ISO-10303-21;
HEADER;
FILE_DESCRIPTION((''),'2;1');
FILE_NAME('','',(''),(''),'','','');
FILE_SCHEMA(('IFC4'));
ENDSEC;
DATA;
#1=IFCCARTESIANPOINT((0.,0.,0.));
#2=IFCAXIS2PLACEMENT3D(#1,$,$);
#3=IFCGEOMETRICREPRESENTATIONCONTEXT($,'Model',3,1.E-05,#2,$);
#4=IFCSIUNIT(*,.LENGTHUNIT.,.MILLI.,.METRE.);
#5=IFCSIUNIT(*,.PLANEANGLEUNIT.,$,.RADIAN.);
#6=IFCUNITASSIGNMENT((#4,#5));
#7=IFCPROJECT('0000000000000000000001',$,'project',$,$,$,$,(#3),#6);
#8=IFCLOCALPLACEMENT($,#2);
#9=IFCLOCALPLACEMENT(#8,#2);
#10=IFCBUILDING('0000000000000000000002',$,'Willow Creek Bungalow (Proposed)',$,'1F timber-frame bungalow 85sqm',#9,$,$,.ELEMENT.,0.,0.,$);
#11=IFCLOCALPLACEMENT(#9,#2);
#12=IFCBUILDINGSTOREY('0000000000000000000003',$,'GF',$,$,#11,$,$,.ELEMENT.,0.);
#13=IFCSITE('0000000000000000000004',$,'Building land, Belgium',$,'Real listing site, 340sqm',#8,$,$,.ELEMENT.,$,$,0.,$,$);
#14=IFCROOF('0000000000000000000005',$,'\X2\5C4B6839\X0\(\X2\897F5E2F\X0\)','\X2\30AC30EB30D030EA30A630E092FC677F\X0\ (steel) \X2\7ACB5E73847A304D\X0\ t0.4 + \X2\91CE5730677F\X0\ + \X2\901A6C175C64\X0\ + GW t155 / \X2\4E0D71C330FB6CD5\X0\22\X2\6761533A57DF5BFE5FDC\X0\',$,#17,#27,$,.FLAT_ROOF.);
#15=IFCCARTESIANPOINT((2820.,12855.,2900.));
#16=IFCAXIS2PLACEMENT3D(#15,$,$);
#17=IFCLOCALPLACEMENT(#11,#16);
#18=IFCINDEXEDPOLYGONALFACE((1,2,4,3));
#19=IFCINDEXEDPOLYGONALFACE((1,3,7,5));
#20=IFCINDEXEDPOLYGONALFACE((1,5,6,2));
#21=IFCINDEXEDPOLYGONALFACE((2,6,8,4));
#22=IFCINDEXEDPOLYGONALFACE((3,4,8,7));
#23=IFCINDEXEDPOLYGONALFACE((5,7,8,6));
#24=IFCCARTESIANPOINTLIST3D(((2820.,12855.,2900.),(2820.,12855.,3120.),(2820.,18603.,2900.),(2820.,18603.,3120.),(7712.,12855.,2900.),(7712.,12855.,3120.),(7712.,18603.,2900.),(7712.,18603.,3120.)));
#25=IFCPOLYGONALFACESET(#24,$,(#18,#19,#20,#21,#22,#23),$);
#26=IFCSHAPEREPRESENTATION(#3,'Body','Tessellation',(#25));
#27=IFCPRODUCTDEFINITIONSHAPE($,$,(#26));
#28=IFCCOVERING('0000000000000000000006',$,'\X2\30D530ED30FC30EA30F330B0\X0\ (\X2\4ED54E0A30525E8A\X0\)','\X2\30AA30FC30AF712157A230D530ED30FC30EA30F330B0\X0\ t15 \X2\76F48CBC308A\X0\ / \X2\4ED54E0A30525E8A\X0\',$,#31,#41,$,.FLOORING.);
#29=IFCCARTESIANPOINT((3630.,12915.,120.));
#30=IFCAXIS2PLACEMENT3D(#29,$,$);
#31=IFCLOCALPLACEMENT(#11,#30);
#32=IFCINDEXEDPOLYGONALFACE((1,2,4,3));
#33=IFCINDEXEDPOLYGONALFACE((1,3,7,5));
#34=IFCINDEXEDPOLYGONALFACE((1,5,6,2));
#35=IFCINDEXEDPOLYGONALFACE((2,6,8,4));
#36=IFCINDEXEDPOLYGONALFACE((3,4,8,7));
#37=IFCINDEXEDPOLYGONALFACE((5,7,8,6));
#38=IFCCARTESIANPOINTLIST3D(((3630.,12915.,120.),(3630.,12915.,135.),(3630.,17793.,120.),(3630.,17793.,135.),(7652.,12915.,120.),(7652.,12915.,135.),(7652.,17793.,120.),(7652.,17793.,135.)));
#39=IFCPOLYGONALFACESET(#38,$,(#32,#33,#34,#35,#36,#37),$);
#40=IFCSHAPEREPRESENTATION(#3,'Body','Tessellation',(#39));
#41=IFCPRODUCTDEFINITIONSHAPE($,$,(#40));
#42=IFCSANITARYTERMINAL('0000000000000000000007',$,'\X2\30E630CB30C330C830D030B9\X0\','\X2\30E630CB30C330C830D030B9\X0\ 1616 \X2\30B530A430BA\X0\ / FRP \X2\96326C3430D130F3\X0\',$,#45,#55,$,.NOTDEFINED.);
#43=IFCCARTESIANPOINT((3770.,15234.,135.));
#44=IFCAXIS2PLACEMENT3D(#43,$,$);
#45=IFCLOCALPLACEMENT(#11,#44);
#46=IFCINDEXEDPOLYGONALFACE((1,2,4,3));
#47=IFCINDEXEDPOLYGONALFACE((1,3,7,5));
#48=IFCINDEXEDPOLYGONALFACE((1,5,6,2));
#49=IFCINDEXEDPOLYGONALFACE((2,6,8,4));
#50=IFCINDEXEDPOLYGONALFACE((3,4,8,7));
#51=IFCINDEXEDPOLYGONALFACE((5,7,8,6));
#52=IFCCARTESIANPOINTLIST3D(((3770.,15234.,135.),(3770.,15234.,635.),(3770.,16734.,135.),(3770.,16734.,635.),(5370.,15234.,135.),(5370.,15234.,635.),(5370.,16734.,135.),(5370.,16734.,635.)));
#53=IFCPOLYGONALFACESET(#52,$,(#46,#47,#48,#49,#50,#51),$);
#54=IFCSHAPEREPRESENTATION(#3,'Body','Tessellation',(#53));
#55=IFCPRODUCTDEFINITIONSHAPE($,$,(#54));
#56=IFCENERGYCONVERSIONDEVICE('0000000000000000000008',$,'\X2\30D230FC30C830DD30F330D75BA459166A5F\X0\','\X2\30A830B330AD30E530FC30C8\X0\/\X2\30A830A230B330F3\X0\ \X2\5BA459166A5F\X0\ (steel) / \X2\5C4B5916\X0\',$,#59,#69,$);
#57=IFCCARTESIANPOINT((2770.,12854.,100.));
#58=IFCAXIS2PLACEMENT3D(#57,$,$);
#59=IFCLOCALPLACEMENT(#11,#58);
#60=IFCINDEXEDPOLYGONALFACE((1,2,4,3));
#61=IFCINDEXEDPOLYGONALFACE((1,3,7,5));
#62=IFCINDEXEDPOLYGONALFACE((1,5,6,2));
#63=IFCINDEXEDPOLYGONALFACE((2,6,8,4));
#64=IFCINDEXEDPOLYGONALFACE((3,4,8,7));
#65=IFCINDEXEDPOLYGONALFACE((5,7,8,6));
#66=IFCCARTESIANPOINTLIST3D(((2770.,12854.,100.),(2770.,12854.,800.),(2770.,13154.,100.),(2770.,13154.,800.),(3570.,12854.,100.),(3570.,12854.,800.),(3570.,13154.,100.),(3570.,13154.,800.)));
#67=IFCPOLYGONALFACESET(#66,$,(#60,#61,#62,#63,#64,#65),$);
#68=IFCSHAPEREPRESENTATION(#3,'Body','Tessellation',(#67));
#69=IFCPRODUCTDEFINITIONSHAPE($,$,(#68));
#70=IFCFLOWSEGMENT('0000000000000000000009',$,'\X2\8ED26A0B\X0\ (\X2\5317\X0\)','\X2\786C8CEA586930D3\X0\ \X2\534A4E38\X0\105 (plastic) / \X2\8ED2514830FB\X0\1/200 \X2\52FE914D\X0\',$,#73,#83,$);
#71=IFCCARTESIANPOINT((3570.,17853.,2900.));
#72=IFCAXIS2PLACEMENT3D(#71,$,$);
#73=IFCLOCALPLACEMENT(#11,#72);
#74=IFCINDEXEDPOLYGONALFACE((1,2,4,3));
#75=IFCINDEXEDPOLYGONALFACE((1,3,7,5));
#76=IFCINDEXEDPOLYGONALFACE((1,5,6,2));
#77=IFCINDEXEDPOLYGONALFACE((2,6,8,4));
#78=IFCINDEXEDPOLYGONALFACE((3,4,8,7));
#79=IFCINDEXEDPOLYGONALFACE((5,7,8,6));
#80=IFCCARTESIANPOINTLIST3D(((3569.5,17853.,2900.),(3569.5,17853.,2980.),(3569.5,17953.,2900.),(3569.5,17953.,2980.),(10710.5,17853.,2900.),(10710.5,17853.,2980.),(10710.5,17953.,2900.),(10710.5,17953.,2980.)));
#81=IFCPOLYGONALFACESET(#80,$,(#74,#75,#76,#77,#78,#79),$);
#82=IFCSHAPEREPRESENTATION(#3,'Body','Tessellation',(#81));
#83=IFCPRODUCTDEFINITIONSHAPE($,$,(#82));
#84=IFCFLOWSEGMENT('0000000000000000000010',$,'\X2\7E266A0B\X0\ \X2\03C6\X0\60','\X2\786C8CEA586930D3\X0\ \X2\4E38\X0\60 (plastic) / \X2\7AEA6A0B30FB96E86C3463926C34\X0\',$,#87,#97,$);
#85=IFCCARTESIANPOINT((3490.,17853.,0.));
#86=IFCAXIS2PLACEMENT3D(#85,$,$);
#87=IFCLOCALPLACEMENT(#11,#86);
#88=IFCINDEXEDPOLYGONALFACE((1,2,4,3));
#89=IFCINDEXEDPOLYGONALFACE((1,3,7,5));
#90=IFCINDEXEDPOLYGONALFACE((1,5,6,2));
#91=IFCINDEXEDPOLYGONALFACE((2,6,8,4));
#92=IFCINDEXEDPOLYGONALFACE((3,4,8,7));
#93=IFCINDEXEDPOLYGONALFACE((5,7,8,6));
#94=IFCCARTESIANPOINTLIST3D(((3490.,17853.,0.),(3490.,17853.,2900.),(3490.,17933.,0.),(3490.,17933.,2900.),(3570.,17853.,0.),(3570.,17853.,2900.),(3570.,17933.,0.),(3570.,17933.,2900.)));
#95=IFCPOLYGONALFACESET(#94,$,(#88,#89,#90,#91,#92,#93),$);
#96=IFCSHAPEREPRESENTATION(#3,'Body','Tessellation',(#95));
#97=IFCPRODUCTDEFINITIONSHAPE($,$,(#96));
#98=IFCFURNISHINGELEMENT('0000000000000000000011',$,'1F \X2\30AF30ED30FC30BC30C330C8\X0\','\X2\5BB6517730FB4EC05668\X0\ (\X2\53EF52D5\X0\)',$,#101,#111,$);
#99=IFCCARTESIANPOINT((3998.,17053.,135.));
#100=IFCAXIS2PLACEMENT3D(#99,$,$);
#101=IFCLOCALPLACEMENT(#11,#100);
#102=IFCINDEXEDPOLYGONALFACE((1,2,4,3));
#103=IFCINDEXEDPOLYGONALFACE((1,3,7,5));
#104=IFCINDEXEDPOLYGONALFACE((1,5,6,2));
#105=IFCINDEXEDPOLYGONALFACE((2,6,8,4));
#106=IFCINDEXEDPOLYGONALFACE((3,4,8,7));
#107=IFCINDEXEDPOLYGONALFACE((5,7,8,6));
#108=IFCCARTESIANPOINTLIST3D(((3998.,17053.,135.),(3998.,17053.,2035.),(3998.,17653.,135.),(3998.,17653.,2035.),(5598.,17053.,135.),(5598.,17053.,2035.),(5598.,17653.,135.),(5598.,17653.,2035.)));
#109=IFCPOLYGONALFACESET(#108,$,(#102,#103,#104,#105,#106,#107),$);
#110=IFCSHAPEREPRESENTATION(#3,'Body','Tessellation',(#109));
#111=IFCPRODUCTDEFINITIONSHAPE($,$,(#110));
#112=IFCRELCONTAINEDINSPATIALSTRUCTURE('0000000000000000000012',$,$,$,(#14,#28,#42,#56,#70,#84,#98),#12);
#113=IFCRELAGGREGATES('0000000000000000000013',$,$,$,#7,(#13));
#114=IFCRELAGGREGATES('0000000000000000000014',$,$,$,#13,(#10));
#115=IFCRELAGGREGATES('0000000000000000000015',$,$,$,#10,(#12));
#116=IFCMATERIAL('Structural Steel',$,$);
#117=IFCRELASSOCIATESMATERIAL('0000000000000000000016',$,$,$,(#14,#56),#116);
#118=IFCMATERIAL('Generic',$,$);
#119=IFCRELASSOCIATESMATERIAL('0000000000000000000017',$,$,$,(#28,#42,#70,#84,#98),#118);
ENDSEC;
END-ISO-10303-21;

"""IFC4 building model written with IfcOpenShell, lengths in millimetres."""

from ifc_helpers import new_model, si_unit, frame, frame_2d, origin, place, context, project, spatial, rectangle, extrude, material, element, save


model = new_model("IFC4")

# Units and contexts
model_context = context("Model", 3, precision=1e-05, world=origin())
ifc_project = project(units=[si_unit("LENGTHUNIT", "METRE", prefix="MILLI"), si_unit("PLANEANGLEUNIT", "RADIAN")], contexts=[model_context])

# Site, building, storey
site_placement = place(None, origin())
site = spatial("IfcSite", under=ifc_project, at=site_placement, Name="Building land, Belgium", ObjectType="Real listing site, 340sqm", CompositionType="ELEMENT", RefElevation=0.0)
building_placement = place(site_placement, origin())
building = spatial("IfcBuilding", under=site, at=building_placement, Name="Willow Creek Bungalow (Proposed)", ObjectType="1F timber-frame bungalow 85sqm", CompositionType="ELEMENT", ElevationOfRefHeight=0.0, ElevationOfTerrain=0.0)
storey_placement = place(building_placement, origin())
storey = spatial("IfcBuildingStorey", under=building, at=storey_placement, Name="GF", CompositionType="ELEMENT", Elevation=0.0)

# Roof
ifc_material_1 = material(Name="Structural Steel")
roof_placement = place(storey_placement, frame((2820.0, 12855.0, 2900.0)))
element("IfcRoof", 1, at=roof_placement, inside=storey, material=ifc_material_1, Name="屋根(西帯)", Description="ガルバリウム鋼板 (steel) 立平葺き t0.4 + 野地板 + 通気層 + GW t155 / 不燃・法22条区域対応", PredefinedType="FLAT_ROOF", context=model_context, shape_type="SweptSolid", body=[
    extrude(rectangle(XDim=4892.0, YDim=5748.0, at=frame_2d((2446.0, 2874.0))), frame((2820.0, 12855.0, 2900.0)), (0.0, 0.0, 1.0), 220.0),
])

# Covering
ifc_material_2 = material(Name="Generic")
covering_placement = place(storey_placement, frame((3630.0, 12915.0, 120.0)))
element("IfcCovering", 2, at=covering_placement, inside=storey, material=ifc_material_2, Name="フローリング (仕上げ床)", Description="オーク無垢フローリング t15 直貼り / 仕上げ床", PredefinedType="FLOORING", context=model_context, shape_type="SweptSolid", body=[
    extrude(rectangle(XDim=4022.0, YDim=4878.0, at=frame_2d((2011.0, 2439.0))), frame((3630.0, 12915.0, 120.0)), (0.0, 0.0, 1.0), 15.0),
])

# Sanitary terminal
sanitary_terminal_placement = place(storey_placement, frame((3770.0, 15234.0, 135.0)))
element("IfcSanitaryTerminal", 3, at=sanitary_terminal_placement, inside=storey, material=ifc_material_2, Name="ユニットバス", Description="ユニットバス 1616 サイズ / FRP 防水パン", PredefinedType="NOTDEFINED", context=model_context, shape_type="SweptSolid", body=[
    extrude(rectangle(XDim=1600.0, YDim=1500.0, at=frame_2d((800.0, 750.0))), frame((3770.0, 15234.0, 135.0)), (0.0, 0.0, 1.0), 500.0),
])

# Energy conversion device
energy_conversion_device_placement = place(storey_placement, frame((2770.0, 12854.0, 100.0)))
element("IfcEnergyConversionDevice", 4, at=energy_conversion_device_placement, inside=storey, material=ifc_material_1, Name="ヒートポンプ室外機", Description="エコキュート/エアコン 室外機 (steel) / 屋外", context=model_context, shape_type="SweptSolid", body=[
    extrude(rectangle(XDim=800.0, YDim=300.0, at=frame_2d((400.0, 150.0))), frame((2770.0, 12854.0, 100.0)), (0.0, 0.0, 1.0), 700.0),
])

# Flow segments
flow_segment_1_placement = place(storey_placement, frame((3570.0, 17853.0, 2900.0)))
element("IfcFlowSegment", 5, at=flow_segment_1_placement, inside=storey, material=ifc_material_2, Name="軒樋 (北)", Description="硬質塩ビ 半丸105 (plastic) / 軒先・1/200 勾配", context=model_context, shape_type="SweptSolid", body=[
    extrude(rectangle(XDim=7141.0, YDim=100.0, at=frame_2d((3570.0, 50.0))), frame((3570.0, 17853.0, 2900.0)), (0.0, 0.0, 1.0), 80.0),
])
flow_segment_2_placement = place(storey_placement, frame((3490.0, 17853.0, 0.0)))
element("IfcFlowSegment", 6, at=flow_segment_2_placement, inside=storey, material=ifc_material_2, Name="縦樋 φ60", Description="硬質塩ビ 丸60 (plastic) / 竪樋・雨水排水", context=model_context, shape_type="SweptSolid", body=[
    extrude(rectangle(XDim=80.0, YDim=80.0, at=frame_2d((40.0, 40.0))), frame((3490.0, 17853.0, 0.0)), (0.0, 0.0, 1.0), 2900.0),
])

# Furnishing element
furnishing_placement = place(storey_placement, frame((3998.0, 17053.0, 135.0)))
element("IfcFurnishingElement", 7, at=furnishing_placement, inside=storey, material=ifc_material_2, Name="1F クローゼット", Description="家具・什器 (可動)", context=model_context, shape_type="SweptSolid", body=[
    extrude(rectangle(XDim=1600.0, YDim=600.0, at=frame_2d((800.0, 300.0))), frame((3998.0, 17053.0, 135.0)), (0.0, 0.0, 1.0), 1900.0),
])

save(model, "model.ifc")
